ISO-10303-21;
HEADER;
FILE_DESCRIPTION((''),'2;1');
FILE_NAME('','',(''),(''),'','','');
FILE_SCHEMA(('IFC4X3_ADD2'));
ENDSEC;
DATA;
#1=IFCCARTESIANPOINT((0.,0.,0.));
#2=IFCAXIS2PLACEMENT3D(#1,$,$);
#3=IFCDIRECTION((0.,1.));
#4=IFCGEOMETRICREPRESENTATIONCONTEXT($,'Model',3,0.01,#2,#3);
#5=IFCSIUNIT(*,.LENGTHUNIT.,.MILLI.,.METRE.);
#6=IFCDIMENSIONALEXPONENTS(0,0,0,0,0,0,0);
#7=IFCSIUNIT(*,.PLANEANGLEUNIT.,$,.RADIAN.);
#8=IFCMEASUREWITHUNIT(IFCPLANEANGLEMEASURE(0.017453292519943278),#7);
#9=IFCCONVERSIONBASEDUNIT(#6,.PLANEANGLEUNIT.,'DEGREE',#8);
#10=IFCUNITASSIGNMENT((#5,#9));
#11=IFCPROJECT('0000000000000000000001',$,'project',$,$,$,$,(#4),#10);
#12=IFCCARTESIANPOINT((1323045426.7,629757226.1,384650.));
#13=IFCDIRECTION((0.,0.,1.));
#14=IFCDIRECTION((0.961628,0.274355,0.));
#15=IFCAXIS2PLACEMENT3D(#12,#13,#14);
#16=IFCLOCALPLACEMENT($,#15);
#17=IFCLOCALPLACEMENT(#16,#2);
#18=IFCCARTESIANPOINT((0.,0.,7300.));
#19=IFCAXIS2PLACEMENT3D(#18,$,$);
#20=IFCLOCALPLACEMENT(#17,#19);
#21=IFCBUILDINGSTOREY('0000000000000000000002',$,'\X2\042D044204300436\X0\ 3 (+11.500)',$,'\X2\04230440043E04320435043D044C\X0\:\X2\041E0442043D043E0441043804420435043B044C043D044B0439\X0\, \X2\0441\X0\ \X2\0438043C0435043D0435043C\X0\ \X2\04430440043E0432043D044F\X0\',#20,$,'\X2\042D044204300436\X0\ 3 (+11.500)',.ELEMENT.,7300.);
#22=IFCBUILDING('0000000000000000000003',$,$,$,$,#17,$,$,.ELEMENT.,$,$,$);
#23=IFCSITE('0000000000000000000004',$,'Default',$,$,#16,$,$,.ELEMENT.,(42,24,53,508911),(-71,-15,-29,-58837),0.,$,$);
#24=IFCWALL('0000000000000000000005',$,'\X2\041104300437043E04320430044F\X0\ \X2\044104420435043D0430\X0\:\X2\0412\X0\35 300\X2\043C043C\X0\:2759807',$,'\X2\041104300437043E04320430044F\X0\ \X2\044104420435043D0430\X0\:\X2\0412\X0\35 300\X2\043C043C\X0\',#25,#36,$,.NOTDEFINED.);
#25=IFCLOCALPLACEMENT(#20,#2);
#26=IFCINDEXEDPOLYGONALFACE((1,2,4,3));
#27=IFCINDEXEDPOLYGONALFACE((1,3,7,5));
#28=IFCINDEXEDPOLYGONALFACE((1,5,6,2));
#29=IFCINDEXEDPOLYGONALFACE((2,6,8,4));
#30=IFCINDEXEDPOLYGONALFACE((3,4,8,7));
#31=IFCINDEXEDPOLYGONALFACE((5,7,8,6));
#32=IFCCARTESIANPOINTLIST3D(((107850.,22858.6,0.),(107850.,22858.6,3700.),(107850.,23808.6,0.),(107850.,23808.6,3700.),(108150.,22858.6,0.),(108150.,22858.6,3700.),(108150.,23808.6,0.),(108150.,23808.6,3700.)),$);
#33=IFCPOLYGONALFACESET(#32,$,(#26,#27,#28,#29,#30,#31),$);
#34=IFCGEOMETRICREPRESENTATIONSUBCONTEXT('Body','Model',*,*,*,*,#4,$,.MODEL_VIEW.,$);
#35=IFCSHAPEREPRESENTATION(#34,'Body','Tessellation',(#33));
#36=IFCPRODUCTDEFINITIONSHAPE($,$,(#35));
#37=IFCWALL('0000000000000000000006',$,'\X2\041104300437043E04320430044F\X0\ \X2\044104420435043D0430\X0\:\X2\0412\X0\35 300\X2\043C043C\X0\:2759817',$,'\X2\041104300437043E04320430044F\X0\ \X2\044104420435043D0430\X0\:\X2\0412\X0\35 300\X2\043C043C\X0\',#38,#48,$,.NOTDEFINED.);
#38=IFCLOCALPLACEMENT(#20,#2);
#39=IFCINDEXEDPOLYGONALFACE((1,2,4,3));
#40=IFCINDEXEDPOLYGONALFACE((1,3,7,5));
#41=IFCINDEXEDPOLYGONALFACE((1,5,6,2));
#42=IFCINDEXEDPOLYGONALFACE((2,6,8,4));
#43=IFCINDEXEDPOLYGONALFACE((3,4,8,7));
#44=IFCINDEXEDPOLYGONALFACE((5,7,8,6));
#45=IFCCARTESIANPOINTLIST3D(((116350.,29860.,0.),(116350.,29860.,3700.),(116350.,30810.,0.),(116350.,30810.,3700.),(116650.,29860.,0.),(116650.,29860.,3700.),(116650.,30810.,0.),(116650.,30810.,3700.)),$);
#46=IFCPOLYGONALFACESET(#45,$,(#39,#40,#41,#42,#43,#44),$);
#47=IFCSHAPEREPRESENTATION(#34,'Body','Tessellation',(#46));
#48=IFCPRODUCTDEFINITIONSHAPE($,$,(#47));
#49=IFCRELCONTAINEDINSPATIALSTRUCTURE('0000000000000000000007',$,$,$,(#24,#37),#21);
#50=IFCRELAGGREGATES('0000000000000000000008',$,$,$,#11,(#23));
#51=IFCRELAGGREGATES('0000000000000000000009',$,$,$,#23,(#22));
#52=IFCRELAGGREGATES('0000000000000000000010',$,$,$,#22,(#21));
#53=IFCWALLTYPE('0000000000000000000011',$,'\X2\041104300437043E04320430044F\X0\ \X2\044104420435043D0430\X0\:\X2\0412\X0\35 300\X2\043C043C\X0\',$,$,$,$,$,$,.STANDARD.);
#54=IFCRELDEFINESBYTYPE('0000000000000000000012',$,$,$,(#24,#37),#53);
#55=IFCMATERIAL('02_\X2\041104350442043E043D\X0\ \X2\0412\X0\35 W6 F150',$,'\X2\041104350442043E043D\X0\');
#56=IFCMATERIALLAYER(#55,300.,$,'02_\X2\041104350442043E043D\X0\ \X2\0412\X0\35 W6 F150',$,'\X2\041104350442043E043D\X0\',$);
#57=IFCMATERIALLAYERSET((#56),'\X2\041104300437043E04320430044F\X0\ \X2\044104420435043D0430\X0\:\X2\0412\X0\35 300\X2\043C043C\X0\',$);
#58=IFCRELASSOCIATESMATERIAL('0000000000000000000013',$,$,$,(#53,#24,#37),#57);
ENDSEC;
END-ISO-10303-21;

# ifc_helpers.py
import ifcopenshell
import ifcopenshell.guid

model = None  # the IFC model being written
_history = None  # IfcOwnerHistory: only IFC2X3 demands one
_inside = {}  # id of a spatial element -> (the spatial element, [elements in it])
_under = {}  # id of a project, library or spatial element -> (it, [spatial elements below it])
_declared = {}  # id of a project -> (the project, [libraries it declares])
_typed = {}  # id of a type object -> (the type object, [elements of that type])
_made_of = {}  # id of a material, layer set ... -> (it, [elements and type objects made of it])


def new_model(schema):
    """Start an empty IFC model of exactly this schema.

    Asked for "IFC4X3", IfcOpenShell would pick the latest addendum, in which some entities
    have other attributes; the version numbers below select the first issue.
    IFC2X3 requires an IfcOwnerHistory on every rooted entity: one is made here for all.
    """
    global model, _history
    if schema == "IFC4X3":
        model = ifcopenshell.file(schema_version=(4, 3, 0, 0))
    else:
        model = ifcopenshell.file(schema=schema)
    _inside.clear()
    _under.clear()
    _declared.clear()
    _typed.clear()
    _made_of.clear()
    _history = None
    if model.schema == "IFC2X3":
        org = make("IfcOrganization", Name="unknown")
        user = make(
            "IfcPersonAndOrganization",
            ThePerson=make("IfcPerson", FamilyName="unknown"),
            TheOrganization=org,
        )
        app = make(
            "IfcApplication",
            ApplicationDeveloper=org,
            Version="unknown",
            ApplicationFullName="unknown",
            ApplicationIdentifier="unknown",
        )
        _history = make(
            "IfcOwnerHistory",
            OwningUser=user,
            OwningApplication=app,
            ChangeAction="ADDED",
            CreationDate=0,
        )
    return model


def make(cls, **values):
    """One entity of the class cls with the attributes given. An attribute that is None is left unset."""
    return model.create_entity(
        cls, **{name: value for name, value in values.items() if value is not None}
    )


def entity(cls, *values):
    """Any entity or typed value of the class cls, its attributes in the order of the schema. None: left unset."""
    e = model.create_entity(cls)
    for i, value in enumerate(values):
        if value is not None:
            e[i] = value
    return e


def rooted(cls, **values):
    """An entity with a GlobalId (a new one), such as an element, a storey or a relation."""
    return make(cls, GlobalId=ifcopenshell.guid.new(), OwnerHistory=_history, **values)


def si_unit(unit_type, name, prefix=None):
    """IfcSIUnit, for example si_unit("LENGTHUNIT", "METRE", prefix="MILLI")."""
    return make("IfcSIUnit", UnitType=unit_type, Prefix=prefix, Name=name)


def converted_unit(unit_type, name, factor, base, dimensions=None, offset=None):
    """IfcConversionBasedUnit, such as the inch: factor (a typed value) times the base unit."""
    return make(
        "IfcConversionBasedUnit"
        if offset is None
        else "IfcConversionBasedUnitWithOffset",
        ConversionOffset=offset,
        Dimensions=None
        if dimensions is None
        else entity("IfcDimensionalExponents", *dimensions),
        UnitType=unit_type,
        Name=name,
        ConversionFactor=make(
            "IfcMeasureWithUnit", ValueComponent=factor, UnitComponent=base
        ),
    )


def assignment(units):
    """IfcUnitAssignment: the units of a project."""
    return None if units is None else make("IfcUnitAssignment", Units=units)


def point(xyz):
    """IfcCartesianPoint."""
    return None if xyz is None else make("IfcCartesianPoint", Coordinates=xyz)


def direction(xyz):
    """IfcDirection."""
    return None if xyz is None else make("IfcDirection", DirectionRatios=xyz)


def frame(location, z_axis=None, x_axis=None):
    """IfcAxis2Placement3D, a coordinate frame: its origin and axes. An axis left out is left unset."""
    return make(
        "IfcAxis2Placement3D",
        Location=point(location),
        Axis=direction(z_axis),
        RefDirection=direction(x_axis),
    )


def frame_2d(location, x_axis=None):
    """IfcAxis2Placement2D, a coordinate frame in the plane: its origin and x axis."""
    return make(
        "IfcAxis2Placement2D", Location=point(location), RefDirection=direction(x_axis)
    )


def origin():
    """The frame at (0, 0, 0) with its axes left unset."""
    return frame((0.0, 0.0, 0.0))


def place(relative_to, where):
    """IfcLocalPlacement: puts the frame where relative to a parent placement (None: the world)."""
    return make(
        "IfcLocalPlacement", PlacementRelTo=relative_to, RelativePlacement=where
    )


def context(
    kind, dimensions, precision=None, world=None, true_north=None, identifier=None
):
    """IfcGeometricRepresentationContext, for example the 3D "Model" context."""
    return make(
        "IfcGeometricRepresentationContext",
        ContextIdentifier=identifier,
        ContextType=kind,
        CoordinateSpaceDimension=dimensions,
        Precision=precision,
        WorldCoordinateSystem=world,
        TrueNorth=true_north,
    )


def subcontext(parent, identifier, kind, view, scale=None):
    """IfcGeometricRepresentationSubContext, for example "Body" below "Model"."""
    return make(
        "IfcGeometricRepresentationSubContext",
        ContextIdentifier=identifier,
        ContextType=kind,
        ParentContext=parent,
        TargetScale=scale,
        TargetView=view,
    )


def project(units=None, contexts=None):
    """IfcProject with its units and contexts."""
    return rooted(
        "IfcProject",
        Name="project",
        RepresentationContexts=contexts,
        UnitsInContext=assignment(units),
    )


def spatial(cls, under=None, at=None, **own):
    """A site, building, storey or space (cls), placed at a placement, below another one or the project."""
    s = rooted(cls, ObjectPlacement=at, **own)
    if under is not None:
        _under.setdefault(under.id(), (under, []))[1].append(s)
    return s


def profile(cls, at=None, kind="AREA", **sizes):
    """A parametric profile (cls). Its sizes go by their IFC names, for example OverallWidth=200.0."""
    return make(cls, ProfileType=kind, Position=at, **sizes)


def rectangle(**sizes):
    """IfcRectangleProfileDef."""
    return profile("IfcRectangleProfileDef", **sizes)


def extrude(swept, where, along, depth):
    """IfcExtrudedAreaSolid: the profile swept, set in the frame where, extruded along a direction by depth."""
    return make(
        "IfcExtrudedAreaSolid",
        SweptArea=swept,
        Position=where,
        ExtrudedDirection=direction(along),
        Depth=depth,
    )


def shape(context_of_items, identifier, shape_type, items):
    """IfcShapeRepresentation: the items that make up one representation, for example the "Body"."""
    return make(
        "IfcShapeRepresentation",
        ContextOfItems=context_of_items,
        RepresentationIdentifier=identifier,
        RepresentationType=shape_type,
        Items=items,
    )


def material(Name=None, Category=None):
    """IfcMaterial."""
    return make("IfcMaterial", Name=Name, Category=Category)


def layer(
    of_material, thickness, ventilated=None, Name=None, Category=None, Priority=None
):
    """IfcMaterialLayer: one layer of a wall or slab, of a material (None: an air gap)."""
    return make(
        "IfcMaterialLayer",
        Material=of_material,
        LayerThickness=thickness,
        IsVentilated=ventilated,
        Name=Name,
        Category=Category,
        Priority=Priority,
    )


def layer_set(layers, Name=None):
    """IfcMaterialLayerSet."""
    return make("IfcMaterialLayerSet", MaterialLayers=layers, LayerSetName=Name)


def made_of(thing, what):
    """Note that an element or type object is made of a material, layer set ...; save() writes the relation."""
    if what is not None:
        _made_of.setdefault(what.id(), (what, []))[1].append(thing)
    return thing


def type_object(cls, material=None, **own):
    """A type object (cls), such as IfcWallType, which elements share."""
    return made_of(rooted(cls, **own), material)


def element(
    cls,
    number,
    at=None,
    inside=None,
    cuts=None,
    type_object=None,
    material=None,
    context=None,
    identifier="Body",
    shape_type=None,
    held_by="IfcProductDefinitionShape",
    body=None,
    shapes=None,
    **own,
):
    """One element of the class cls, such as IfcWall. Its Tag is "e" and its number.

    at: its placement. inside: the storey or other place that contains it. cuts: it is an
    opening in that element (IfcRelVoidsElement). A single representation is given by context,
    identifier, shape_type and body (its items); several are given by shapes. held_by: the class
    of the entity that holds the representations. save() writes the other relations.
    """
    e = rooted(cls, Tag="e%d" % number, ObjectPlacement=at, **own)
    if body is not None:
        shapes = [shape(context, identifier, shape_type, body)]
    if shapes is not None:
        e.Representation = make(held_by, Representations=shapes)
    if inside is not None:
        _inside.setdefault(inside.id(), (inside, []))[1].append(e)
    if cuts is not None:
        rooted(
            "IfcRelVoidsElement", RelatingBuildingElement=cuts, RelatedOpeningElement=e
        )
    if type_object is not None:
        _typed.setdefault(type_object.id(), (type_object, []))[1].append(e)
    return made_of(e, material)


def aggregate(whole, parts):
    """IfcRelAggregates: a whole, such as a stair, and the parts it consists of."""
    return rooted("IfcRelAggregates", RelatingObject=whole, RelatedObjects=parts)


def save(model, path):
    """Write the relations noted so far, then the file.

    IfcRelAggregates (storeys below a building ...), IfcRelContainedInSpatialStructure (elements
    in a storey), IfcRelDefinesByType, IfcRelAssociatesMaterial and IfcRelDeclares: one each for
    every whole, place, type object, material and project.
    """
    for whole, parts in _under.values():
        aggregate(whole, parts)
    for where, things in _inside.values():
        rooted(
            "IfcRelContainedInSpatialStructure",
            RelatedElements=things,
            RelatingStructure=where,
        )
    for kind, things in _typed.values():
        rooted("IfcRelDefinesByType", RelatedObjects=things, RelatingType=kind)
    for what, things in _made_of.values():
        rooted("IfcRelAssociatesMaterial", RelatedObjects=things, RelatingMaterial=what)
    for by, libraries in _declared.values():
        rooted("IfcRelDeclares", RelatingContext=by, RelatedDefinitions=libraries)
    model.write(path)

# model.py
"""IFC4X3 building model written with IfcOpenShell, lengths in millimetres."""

from ifc_helpers import new_model, entity, si_unit, converted_unit, direction, frame, frame_2d, origin, place, context, subcontext, project, spatial, rectangle, extrude, material, layer, layer_set, type_object, element, save


model = new_model("IFC4X3")

# Units and contexts
model_context = context("Model", 3, precision=0.01, world=origin(), true_north=direction((0.0, 1.0)))
body_context = subcontext(model_context, "Body", "Model", "MODEL_VIEW")
ifc_project = project(units=[si_unit("LENGTHUNIT", "METRE", prefix="MILLI"), converted_unit("PLANEANGLEUNIT", "DEGREE", entity("IfcPlaneAngleMeasure", 0.017453292519943278), si_unit("PLANEANGLEUNIT", "RADIAN"), dimensions=[0, 0, 0, 0, 0, 0, 0])], contexts=[model_context])

# Site, building, storey
site_placement = place(None, frame((1323045426.7, 629757226.1, 384650.0), z_axis=(0.0, 0.0, 1.0), x_axis=(0.961628, 0.274355, 0.0)))
site = spatial("IfcSite", under=ifc_project, at=site_placement, Name="Default", CompositionType="ELEMENT", RefLatitude=(42, 24, 53, 508911), RefLongitude=(-71, -15, -29, -58837), RefElevation=0.0)
building_placement = place(site_placement, origin())
building = spatial("IfcBuilding", under=site, at=building_placement, CompositionType="ELEMENT")
storey_placement = place(building_placement, frame((0.0, 0.0, 7300.0)))
storey = spatial("IfcBuildingStorey", under=building, at=storey_placement, Name="Этаж 3 (+11.500)", ObjectType="Уровень:Относительный, с именем уровня", LongName="Этаж 3 (+11.500)", CompositionType="ELEMENT", Elevation=7300.0)

# Shared definitions
ifc_material = material(Name="02_Бетон В35 W6 F150", Category="Бетон")

# Walls
ifc_layer_1 = layer(ifc_material, 300.0, Name="02_Бетон В35 W6 F150", Category="Бетон")
ifc_layer_set_1 = layer_set([ifc_layer_1], Name="Базовая стена:В35 300мм")
wall_type_1 = type_object("IfcWallType", Name="Базовая стена:В35 300мм", PredefinedType="STANDARD", material=ifc_layer_set_1)
for number, where, z_axis, x_axis, name in (
    (1, (108000.0, 22858.6, 0.0), (0.0, 0.0, 1.0), (0.0, 1.0, 0.0), "Базовая стена:В35 300мм:2759807"),
    (2, (116500.0, 29860.0, 0.0), (0.0, 0.0, 1.0), (0.0, 1.0, 0.0), "Базовая стена:В35 300мм:2759817"),
):
    element("IfcWall", number, at=place(storey_placement, frame(where, z_axis=z_axis, x_axis=x_axis)), inside=storey, type_object=wall_type_1, material=ifc_layer_set_1, Name=name, ObjectType="Базовая стена:В35 300мм", PredefinedType="NOTDEFINED", context=body_context, shape_type="SweptSolid", body=[
        extrude(rectangle(XDim=950.0, YDim=300.0, at=frame_2d((475.0, 0.0), x_axis=(-1.0, 0.0))), origin(), (0.0, 0.0, 1.0), 3700.0),
    ])

save(model, "model.ifc")
